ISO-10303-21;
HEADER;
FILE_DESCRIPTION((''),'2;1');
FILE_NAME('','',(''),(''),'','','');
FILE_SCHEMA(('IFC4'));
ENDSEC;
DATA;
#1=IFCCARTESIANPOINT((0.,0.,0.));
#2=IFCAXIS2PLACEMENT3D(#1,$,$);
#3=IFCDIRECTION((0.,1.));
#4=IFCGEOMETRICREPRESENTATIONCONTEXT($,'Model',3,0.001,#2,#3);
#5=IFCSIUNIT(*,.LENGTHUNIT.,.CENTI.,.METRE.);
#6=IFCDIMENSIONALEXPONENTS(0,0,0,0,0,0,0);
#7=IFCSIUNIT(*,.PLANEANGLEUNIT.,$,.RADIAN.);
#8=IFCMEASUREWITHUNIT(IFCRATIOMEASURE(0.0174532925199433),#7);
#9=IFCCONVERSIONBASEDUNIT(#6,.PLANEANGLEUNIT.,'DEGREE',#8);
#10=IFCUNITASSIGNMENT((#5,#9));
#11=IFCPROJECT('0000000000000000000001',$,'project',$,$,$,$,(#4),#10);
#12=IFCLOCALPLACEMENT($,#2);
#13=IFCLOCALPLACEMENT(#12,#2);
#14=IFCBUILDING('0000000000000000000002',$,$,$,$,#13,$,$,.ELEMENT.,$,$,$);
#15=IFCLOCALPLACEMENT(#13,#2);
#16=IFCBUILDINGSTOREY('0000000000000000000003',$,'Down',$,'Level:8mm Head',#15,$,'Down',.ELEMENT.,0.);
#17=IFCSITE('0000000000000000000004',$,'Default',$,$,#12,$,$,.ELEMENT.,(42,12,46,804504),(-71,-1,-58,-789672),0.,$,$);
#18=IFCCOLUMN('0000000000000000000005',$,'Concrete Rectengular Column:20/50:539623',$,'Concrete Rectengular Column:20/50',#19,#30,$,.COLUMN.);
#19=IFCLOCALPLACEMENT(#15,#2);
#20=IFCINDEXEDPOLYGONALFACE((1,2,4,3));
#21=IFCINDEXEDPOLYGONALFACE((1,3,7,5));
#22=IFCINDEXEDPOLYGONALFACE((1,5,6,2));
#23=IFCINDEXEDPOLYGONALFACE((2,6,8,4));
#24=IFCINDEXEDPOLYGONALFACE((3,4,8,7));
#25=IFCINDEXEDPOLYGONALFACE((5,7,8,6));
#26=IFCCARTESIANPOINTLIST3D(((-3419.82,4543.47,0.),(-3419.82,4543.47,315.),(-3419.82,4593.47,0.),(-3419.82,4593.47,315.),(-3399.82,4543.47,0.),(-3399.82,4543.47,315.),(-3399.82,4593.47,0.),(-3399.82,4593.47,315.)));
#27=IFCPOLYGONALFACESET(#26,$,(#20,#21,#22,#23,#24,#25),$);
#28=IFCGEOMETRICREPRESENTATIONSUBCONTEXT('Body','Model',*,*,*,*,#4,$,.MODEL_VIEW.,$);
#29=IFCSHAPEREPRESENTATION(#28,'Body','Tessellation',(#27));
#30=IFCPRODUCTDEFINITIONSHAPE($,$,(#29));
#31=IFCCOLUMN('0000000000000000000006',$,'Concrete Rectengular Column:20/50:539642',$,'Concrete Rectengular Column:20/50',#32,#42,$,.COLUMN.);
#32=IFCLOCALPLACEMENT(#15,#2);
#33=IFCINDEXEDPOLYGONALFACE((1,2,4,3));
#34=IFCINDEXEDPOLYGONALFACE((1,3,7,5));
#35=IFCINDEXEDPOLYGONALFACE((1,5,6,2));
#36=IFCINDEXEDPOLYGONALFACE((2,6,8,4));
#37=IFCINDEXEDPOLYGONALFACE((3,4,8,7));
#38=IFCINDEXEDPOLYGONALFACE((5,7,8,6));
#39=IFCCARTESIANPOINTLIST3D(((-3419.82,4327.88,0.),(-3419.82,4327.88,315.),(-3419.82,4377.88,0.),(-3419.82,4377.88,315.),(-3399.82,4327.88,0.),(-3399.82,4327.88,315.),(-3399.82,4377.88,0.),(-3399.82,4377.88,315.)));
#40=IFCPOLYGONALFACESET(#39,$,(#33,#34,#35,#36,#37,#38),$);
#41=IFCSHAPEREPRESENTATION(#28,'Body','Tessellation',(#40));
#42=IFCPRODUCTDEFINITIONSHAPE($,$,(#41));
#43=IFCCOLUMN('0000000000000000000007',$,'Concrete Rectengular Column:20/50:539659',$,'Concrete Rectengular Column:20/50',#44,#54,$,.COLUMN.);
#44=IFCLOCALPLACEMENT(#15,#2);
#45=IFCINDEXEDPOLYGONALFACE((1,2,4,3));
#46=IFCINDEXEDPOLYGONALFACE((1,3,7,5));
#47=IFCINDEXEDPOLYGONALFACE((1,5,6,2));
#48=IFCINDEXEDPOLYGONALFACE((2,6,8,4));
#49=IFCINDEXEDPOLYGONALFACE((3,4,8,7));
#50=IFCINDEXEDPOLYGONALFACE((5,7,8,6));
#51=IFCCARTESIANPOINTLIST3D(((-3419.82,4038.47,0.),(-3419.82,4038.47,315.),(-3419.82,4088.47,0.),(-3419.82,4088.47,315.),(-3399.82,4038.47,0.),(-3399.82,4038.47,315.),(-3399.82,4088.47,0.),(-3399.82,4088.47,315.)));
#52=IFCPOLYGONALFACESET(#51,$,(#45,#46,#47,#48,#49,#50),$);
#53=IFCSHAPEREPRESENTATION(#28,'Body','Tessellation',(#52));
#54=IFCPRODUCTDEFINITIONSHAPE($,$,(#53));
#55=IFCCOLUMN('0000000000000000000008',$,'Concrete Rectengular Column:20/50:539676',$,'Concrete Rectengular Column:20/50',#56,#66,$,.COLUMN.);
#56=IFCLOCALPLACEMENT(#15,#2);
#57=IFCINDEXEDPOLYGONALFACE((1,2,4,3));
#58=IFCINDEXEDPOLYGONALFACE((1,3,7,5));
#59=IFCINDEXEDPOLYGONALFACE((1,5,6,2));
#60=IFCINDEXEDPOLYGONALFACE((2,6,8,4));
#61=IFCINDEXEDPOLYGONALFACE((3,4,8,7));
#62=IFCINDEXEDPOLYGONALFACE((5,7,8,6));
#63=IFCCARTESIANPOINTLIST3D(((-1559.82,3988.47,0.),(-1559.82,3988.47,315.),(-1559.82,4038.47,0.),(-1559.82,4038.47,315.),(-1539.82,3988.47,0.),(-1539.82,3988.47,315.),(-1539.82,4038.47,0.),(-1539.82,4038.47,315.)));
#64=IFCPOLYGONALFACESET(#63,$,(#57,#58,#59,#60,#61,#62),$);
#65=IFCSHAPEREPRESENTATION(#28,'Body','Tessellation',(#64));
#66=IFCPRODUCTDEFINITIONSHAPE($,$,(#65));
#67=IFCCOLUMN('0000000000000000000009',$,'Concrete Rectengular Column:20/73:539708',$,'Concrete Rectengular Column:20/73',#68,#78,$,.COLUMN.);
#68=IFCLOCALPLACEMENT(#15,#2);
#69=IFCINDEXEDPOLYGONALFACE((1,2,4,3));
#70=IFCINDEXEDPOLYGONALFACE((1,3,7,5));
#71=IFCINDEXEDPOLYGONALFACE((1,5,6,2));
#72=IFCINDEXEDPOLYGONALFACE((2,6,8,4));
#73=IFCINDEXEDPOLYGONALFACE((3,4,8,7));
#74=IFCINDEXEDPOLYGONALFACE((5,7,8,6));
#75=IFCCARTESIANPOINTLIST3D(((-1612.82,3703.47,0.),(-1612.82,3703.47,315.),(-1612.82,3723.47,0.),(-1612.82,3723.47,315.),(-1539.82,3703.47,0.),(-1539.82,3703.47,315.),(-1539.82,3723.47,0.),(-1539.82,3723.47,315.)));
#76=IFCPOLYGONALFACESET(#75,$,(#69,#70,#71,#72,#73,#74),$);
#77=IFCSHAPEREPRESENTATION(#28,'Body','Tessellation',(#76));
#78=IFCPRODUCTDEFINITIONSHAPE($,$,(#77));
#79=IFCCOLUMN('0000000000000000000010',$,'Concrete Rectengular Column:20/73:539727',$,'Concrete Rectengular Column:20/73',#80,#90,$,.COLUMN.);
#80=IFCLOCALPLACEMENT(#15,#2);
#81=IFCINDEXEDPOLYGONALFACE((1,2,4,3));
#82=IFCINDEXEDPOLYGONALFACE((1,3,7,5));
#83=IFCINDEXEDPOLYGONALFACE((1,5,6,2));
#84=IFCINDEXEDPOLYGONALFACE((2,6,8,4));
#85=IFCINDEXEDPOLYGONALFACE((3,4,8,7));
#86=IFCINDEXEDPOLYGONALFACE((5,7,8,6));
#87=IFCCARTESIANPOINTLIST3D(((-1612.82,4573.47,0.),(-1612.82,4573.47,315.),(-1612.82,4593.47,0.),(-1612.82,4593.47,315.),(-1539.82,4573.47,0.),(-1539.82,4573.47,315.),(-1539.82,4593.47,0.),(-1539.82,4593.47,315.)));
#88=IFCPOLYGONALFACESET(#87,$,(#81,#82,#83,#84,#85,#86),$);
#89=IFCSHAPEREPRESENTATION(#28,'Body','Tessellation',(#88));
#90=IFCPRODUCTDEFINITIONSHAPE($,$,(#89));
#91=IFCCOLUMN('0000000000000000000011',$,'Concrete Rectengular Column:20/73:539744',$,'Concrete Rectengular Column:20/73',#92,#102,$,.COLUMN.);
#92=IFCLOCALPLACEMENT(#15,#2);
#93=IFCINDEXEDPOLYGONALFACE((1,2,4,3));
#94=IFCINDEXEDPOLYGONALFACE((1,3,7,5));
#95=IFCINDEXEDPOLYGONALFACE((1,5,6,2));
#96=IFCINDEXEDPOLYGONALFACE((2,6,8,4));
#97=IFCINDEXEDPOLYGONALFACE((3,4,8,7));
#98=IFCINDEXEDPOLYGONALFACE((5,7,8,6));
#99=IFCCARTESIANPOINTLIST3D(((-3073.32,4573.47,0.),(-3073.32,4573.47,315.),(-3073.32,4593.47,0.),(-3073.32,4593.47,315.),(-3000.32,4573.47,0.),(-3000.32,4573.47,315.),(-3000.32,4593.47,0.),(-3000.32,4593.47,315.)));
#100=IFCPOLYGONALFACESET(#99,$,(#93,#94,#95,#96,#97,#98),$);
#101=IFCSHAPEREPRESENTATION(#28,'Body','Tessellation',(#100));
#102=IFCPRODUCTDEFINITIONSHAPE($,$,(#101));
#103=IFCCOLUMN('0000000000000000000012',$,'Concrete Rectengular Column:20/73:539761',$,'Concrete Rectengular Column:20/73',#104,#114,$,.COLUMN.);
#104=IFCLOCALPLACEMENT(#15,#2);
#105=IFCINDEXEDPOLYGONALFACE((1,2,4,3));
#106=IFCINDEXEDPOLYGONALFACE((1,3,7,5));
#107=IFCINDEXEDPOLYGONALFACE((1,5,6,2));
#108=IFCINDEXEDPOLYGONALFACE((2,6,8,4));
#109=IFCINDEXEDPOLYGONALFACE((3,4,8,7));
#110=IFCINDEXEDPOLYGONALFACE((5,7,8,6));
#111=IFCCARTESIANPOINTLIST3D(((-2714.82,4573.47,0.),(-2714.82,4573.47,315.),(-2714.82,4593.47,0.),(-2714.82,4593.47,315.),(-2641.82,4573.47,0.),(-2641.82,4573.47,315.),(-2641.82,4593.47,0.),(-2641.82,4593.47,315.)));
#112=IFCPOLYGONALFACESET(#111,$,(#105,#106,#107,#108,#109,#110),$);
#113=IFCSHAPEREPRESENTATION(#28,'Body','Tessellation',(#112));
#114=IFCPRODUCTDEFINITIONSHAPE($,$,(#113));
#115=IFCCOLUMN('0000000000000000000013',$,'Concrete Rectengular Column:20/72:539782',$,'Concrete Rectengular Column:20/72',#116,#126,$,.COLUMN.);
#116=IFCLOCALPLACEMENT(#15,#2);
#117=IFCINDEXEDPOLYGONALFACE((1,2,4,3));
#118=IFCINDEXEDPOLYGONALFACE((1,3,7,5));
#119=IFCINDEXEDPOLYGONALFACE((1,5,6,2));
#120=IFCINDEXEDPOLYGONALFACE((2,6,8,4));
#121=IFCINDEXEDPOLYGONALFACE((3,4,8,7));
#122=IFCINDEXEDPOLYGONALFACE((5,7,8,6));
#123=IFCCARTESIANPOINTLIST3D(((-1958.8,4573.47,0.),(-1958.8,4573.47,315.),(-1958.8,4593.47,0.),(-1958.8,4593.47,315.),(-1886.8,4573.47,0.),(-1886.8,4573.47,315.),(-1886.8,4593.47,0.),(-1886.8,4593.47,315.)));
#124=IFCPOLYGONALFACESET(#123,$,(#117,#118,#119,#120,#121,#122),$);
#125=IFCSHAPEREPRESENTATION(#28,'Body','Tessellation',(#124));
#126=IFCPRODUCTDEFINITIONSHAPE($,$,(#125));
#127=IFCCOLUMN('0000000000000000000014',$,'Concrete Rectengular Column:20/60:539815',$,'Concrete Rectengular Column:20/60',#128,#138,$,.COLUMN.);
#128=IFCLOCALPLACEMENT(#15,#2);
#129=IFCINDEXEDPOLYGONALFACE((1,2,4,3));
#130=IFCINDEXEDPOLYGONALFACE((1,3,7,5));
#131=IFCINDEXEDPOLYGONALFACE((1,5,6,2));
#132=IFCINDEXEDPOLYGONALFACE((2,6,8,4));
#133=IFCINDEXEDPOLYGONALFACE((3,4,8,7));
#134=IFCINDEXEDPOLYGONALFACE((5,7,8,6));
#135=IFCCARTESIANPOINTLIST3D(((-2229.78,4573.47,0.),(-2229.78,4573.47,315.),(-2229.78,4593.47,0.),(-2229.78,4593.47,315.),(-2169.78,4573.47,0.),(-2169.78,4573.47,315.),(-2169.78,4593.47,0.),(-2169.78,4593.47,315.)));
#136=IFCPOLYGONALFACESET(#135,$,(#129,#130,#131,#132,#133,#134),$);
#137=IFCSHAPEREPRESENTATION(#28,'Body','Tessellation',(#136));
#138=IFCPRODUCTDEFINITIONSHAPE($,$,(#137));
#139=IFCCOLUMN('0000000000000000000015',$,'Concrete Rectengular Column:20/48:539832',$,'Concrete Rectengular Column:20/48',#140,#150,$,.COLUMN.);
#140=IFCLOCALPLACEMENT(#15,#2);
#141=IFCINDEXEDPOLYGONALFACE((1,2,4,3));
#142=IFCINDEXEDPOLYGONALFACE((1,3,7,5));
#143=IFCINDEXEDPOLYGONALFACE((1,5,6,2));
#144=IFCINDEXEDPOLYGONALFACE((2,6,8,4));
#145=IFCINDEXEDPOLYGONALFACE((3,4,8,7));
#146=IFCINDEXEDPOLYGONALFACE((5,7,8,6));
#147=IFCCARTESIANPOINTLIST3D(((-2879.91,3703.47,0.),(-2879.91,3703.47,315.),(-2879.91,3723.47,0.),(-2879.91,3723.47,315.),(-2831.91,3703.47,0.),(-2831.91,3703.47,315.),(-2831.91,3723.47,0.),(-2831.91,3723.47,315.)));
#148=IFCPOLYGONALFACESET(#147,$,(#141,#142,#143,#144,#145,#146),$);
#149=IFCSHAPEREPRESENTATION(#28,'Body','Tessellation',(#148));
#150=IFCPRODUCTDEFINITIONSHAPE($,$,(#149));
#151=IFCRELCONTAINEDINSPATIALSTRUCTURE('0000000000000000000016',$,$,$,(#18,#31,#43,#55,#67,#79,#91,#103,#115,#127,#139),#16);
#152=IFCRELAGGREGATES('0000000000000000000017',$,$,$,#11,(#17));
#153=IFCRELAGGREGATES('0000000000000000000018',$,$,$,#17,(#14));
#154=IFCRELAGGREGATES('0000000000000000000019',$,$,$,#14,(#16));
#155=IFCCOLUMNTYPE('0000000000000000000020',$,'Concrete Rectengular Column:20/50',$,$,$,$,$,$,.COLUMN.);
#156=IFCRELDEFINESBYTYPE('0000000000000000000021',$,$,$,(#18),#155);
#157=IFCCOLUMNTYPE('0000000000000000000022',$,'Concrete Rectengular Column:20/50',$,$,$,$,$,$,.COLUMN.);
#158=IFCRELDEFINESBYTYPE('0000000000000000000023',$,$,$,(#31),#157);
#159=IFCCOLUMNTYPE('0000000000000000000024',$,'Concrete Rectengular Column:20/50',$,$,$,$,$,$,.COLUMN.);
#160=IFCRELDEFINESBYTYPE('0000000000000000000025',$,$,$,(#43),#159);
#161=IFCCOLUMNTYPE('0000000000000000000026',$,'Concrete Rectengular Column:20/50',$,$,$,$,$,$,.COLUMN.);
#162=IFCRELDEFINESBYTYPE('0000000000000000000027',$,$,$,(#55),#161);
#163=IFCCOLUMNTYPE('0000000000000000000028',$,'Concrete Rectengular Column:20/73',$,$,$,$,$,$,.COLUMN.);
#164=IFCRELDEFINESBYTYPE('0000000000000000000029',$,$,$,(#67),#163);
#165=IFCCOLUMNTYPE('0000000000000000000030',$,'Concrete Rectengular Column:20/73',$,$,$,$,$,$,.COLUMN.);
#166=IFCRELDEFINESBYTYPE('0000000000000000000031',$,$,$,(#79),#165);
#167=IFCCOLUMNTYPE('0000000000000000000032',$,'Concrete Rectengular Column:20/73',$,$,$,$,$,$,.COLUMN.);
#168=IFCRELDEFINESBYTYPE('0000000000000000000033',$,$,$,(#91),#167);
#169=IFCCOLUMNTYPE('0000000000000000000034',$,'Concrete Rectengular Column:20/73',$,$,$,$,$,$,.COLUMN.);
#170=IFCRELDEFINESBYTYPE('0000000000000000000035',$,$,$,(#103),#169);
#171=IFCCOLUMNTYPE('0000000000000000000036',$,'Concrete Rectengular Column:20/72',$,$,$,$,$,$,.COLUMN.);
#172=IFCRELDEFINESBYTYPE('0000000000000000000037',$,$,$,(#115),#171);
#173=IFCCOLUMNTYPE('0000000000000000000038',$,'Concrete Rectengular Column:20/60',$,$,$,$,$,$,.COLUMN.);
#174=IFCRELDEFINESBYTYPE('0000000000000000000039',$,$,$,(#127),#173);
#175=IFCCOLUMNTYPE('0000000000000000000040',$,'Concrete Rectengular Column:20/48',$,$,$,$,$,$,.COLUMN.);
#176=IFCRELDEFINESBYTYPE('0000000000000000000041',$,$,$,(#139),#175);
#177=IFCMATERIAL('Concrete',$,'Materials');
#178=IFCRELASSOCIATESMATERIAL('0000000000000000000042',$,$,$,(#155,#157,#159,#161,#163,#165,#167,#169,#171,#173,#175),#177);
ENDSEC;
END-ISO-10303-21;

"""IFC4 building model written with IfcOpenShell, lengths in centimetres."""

from ifc_helpers import new_model, entity, si_unit, converted_unit, direction, frame, origin, place, context, subcontext, project, spatial, indexed_curve, outline, extrude, source, transform, mapped, material, type_object, type_shapes, element, save


model = new_model("IFC4")

# Units and contexts
model_context = context("Model", 3, precision=0.001, world=origin(), true_north=direction((0.0, 1.0)))
body_context = subcontext(model_context, "Body", "Model", "MODEL_VIEW")
ifc_project = project(units=[si_unit("LENGTHUNIT", "METRE", prefix="CENTI"), converted_unit("PLANEANGLEUNIT", "DEGREE", entity("IfcRatioMeasure", 0.0174532925199433), si_unit("PLANEANGLEUNIT", "RADIAN"), dimensions=[0, 0, 0, 0, 0, 0, 0])], contexts=[model_context])

# Site, building, storey
site_placement = place(None, origin())
site = spatial("IfcSite", under=ifc_project, at=site_placement, Name="Default", CompositionType="ELEMENT", RefLatitude=(42, 12, 46, 804504), RefLongitude=(-71, -1, -58, -789672), RefElevation=0.0)
building_placement = place(site_placement, origin())
building = spatial("IfcBuilding", under=site, at=building_placement, CompositionType="ELEMENT")
storey_placement = place(building_placement, origin())
storey = spatial("IfcBuildingStorey", under=building, at=storey_placement, Name="Down", ObjectType="Level:8mm Head", LongName="Down", CompositionType="ELEMENT", Elevation=0.0)

# Columns
ifc_material = material(Name="Concrete", Category="Materials")
column_type_1 = type_object("IfcColumnType", Name="Concrete Rectengular Column:20/50", PredefinedType="COLUMN", material=ifc_material)
shared_shape_1 = source(origin(), body_context, "Body", "SweptSolid", [
    extrude(outline(indexed_curve([(-25.0, -10.0), (25.0, -10.0), (25.0, 10.0), (-25.0, 10.0), (-25.0, -10.0)], self_intersect=False)), frame((-3409.82, 4568.47, 0.0), z_axis=(0.0, 0.0, 1.0), x_axis=(0.0, -1.0, 0.0)), (0.0, 0.0, 1.0), 315.0),
])
type_shapes(column_type_1, [shared_shape_1])
column_1_placement = place(storey_placement, origin())
element("IfcColumn", 1, at=column_1_placement, inside=storey, type_object=column_type_1, Name="Concrete Rectengular Column:20/50:539623", ObjectType="Concrete Rectengular Column:20/50", PredefinedType="COLUMN", context=body_context, shape_type="MappedRepresentation", body=[
    mapped(shared_shape_1, transform((0.0, 0.0, 0.0), scale=1.0)),
])
column_type_2 = type_object("IfcColumnType", Name="Concrete Rectengular Column:20/50", PredefinedType="COLUMN", material=ifc_material)
shared_shape_2 = source(origin(), body_context, "Body", "SweptSolid", [
    extrude(outline(indexed_curve([(-25.0, -10.0), (25.0, -10.0), (25.0, 10.0), (-25.0, 10.0), (-25.0, -10.0)], self_intersect=False)), frame((-3409.82, 4352.88, 0.0), z_axis=(0.0, 0.0, 1.0), x_axis=(0.0, -1.0, 0.0)), (0.0, 0.0, 1.0), 315.0),
])
type_shapes(column_type_2, [shared_shape_2])
column_2_placement = place(storey_placement, origin())
element("IfcColumn", 2, at=column_2_placement, inside=storey, type_object=column_type_2, Name="Concrete Rectengular Column:20/50:539642", ObjectType="Concrete Rectengular Column:20/50", PredefinedType="COLUMN", context=body_context, shape_type="MappedRepresentation", body=[
    mapped(shared_shape_2, transform((0.0, 0.0, 0.0), scale=1.0)),
])
column_type_3 = type_object("IfcColumnType", Name="Concrete Rectengular Column:20/50", PredefinedType="COLUMN", material=ifc_material)
shared_shape_3 = source(origin(), body_context, "Body", "SweptSolid", [
    extrude(outline(indexed_curve([(-25.0, -10.0), (25.0, -10.0), (25.0, 10.0), (-25.0, 10.0), (-25.0, -10.0)], self_intersect=False)), frame((-3409.82, 4063.47, 0.0), z_axis=(0.0, 0.0, 1.0), x_axis=(0.0, -1.0, 0.0)), (0.0, 0.0, 1.0), 315.0),
])
type_shapes(column_type_3, [shared_shape_3])
column_3_placement = place(storey_placement, origin())
element("IfcColumn", 3, at=column_3_placement, inside=storey, type_object=column_type_3, Name="Concrete Rectengular Column:20/50:539659", ObjectType="Concrete Rectengular Column:20/50", PredefinedType="COLUMN", context=body_context, shape_type="MappedRepresentation", body=[
    mapped(shared_shape_3, transform((0.0, 0.0, 0.0), scale=1.0)),
])
column_type_4 = type_object("IfcColumnType", Name="Concrete Rectengular Column:20/50", PredefinedType="COLUMN", material=ifc_material)
shared_shape_4 = source(origin(), body_context, "Body", "SweptSolid", [
    extrude(outline(indexed_curve([(-25.0, -10.0), (25.0, -10.0), (25.0, 10.0), (-25.0, 10.0), (-25.0, -10.0)], self_intersect=False)), frame((-1549.82, 4013.47, 0.0), z_axis=(0.0, 0.0, 1.0), x_axis=(0.0, -1.0, 0.0)), (0.0, 0.0, 1.0), 315.0),
])
type_shapes(column_type_4, [shared_shape_4])
column_4_placement = place(storey_placement, origin())
element("IfcColumn", 4, at=column_4_placement, inside=storey, type_object=column_type_4, Name="Concrete Rectengular Column:20/50:539676", ObjectType="Concrete Rectengular Column:20/50", PredefinedType="COLUMN", context=body_context, shape_type="MappedRepresentation", body=[
    mapped(shared_shape_4, transform((0.0, 0.0, 0.0), scale=1.0)),
])
column_type_5 = type_object("IfcColumnType", Name="Concrete Rectengular Column:20/73", PredefinedType="COLUMN", material=ifc_material)
shared_shape_5 = source(origin(), body_context, "Body", "SweptSolid", [
    extrude(outline(indexed_curve([(-10.0, -36.5), (10.0, -36.5), (10.0, 36.5), (-10.0, 36.5), (-10.0, -36.5)], self_intersect=False)), frame((-1576.32, 3713.47, 0.0), z_axis=(0.0, 0.0, 1.0), x_axis=(0.0, -1.0, 0.0)), (0.0, 0.0, 1.0), 315.0),
])
type_shapes(column_type_5, [shared_shape_5])
column_5_placement = place(storey_placement, origin())
element("IfcColumn", 5, at=column_5_placement, inside=storey, type_object=column_type_5, Name="Concrete Rectengular Column:20/73:539708", ObjectType="Concrete Rectengular Column:20/73", PredefinedType="COLUMN", context=body_context, shape_type="MappedRepresentation", body=[
    mapped(shared_shape_5, transform((0.0, 0.0, 0.0), scale=1.0)),
])
column_type_6 = type_object("IfcColumnType", Name="Concrete Rectengular Column:20/73", PredefinedType="COLUMN", material=ifc_material)
shared_shape_6 = source(origin(), body_context, "Body", "SweptSolid", [
    extrude(outline(indexed_curve([(-10.0, -36.5), (10.0, -36.5), (10.0, 36.5), (-10.0, 36.5), (-10.0, -36.5)], self_intersect=False)), frame((-1576.32, 4583.47, 0.0), z_axis=(0.0, 0.0, 1.0), x_axis=(0.0, -1.0, 0.0)), (0.0, 0.0, 1.0), 315.0),
])
type_shapes(column_type_6, [shared_shape_6])
column_6_placement = place(storey_placement, origin())
element("IfcColumn", 6, at=column_6_placement, inside=storey, type_object=column_type_6, Name="Concrete Rectengular Column:20/73:539727", ObjectType="Concrete Rectengular Column:20/73", PredefinedType="COLUMN", context=body_context, shape_type="MappedRepresentation", body=[
    mapped(shared_shape_6, transform((0.0, 0.0, 0.0), scale=1.0)),
])
column_type_7 = type_object("IfcColumnType", Name="Concrete Rectengular Column:20/73", PredefinedType="COLUMN", material=ifc_material)
shared_shape_7 = source(origin(), body_context, "Body", "SweptSolid", [
    extrude(outline(indexed_curve([(-10.0, -36.5), (10.0, -36.5), (10.0, 36.5), (-10.0, 36.5), (-10.0, -36.5)], self_intersect=False)), frame((-3036.82, 4583.47, 0.0), z_axis=(0.0, 0.0, 1.0), x_axis=(0.0, -1.0, 0.0)), (0.0, 0.0, 1.0), 315.0),
])
type_shapes(column_type_7, [shared_shape_7])
column_7_placement = place(storey_placement, origin())
element("IfcColumn", 7, at=column_7_placement, inside=storey, type_object=column_type_7, Name="Concrete Rectengular Column:20/73:539744", ObjectType="Concrete Rectengular Column:20/73", PredefinedType="COLUMN", context=body_context, shape_type="MappedRepresentation", body=[
    mapped(shared_shape_7, transform((0.0, 0.0, 0.0), scale=1.0)),
])
column_type_8 = type_object("IfcColumnType", Name="Concrete Rectengular Column:20/73", PredefinedType="COLUMN", material=ifc_material)
shared_shape_8 = source(origin(), body_context, "Body", "SweptSolid", [
    extrude(outline(indexed_curve([(-10.0, -36.5), (10.0, -36.5), (10.0, 36.5), (-10.0, 36.5), (-10.0, -36.5)], self_intersect=False)), frame((-2678.32, 4583.47, 0.0), z_axis=(0.0, 0.0, 1.0), x_axis=(0.0, -1.0, 0.0)), (0.0, 0.0, 1.0), 315.0),
])
type_shapes(column_type_8, [shared_shape_8])
column_8_placement = place(storey_placement, origin())
element("IfcColumn", 8, at=column_8_placement, inside=storey, type_object=column_type_8, Name="Concrete Rectengular Column:20/73:539761", ObjectType="Concrete Rectengular Column:20/73", PredefinedType="COLUMN", context=body_context, shape_type="MappedRepresentation", body=[
    mapped(shared_shape_8, transform((0.0, 0.0, 0.0), scale=1.0)),
])
column_type_9 = type_object("IfcColumnType", Name="Concrete Rectengular Column:20/72", PredefinedType="COLUMN", material=ifc_material)
shared_shape_9 = source(origin(), body_context, "Body", "SweptSolid", [
    extrude(outline(indexed_curve([(-10.0, -36.0), (10.0, -36.0), (10.0, 36.0), (-10.0, 36.0), (-10.0, -36.0)], self_intersect=False)), frame((-1922.8, 4583.47, 0.0), z_axis=(0.0, 0.0, 1.0), x_axis=(0.0, -1.0, 0.0)), (0.0, 0.0, 1.0), 315.0),
])
type_shapes(column_type_9, [shared_shape_9])
column_9_placement = place(storey_placement, origin())
element("IfcColumn", 9, at=column_9_placement, inside=storey, type_object=column_type_9, Name="Concrete Rectengular Column:20/72:539782", ObjectType="Concrete Rectengular Column:20/72", PredefinedType="COLUMN", context=body_context, shape_type="MappedRepresentation", body=[
    mapped(shared_shape_9, transform((0.0, 0.0, 0.0), scale=1.0)),
])
column_type_10 = type_object("IfcColumnType", Name="Concrete Rectengular Column:20/60", PredefinedType="COLUMN", material=ifc_material)
shared_shape_10 = source(origin(), body_context, "Body", "SweptSolid", [
    extrude(outline(indexed_curve([(-10.0, -30.0), (10.0, -30.0), (10.0, 30.0), (-10.0, 30.0), (-10.0, -30.0)], self_intersect=False)), frame((-2199.78, 4583.47, 0.0), z_axis=(0.0, 0.0, 1.0), x_axis=(0.0, -1.0, 0.0)), (0.0, 0.0, 1.0), 315.0),
])
type_shapes(column_type_10, [shared_shape_10])
column_10_placement = place(storey_placement, origin())
element("IfcColumn", 10, at=column_10_placement, inside=storey, type_object=column_type_10, Name="Concrete Rectengular Column:20/60:539815", ObjectType="Concrete Rectengular Column:20/60", PredefinedType="COLUMN", context=body_context, shape_type="MappedRepresentation", body=[
    mapped(shared_shape_10, transform((0.0, 0.0, 0.0), scale=1.0)),
])
column_type_11 = type_object("IfcColumnType", Name="Concrete Rectengular Column:20/48", PredefinedType="COLUMN", material=ifc_material)
shared_shape_11 = source(origin(), body_context, "Body", "SweptSolid", [
    extrude(outline(indexed_curve([(-10.0, -24.0), (10.0, -24.0), (10.0, 24.0), (-10.0, 24.0), (-10.0, -24.0)], self_intersect=False)), frame((-2855.91, 3713.47, 0.0), z_axis=(0.0, 0.0, 1.0), x_axis=(0.0, -1.0, 0.0)), (0.0, 0.0, 1.0), 315.0),
])
type_shapes(column_type_11, [shared_shape_11])
column_11_placement = place(storey_placement, origin())
element("IfcColumn", 11, at=column_11_placement, inside=storey, type_object=column_type_11, Name="Concrete Rectengular Column:20/48:539832", ObjectType="Concrete Rectengular Column:20/48", PredefinedType="COLUMN", context=body_context, shape_type="MappedRepresentation", body=[
    mapped(shared_shape_11, transform((0.0, 0.0, 0.0), scale=1.0)),
])

save(model, "model.ifc")
